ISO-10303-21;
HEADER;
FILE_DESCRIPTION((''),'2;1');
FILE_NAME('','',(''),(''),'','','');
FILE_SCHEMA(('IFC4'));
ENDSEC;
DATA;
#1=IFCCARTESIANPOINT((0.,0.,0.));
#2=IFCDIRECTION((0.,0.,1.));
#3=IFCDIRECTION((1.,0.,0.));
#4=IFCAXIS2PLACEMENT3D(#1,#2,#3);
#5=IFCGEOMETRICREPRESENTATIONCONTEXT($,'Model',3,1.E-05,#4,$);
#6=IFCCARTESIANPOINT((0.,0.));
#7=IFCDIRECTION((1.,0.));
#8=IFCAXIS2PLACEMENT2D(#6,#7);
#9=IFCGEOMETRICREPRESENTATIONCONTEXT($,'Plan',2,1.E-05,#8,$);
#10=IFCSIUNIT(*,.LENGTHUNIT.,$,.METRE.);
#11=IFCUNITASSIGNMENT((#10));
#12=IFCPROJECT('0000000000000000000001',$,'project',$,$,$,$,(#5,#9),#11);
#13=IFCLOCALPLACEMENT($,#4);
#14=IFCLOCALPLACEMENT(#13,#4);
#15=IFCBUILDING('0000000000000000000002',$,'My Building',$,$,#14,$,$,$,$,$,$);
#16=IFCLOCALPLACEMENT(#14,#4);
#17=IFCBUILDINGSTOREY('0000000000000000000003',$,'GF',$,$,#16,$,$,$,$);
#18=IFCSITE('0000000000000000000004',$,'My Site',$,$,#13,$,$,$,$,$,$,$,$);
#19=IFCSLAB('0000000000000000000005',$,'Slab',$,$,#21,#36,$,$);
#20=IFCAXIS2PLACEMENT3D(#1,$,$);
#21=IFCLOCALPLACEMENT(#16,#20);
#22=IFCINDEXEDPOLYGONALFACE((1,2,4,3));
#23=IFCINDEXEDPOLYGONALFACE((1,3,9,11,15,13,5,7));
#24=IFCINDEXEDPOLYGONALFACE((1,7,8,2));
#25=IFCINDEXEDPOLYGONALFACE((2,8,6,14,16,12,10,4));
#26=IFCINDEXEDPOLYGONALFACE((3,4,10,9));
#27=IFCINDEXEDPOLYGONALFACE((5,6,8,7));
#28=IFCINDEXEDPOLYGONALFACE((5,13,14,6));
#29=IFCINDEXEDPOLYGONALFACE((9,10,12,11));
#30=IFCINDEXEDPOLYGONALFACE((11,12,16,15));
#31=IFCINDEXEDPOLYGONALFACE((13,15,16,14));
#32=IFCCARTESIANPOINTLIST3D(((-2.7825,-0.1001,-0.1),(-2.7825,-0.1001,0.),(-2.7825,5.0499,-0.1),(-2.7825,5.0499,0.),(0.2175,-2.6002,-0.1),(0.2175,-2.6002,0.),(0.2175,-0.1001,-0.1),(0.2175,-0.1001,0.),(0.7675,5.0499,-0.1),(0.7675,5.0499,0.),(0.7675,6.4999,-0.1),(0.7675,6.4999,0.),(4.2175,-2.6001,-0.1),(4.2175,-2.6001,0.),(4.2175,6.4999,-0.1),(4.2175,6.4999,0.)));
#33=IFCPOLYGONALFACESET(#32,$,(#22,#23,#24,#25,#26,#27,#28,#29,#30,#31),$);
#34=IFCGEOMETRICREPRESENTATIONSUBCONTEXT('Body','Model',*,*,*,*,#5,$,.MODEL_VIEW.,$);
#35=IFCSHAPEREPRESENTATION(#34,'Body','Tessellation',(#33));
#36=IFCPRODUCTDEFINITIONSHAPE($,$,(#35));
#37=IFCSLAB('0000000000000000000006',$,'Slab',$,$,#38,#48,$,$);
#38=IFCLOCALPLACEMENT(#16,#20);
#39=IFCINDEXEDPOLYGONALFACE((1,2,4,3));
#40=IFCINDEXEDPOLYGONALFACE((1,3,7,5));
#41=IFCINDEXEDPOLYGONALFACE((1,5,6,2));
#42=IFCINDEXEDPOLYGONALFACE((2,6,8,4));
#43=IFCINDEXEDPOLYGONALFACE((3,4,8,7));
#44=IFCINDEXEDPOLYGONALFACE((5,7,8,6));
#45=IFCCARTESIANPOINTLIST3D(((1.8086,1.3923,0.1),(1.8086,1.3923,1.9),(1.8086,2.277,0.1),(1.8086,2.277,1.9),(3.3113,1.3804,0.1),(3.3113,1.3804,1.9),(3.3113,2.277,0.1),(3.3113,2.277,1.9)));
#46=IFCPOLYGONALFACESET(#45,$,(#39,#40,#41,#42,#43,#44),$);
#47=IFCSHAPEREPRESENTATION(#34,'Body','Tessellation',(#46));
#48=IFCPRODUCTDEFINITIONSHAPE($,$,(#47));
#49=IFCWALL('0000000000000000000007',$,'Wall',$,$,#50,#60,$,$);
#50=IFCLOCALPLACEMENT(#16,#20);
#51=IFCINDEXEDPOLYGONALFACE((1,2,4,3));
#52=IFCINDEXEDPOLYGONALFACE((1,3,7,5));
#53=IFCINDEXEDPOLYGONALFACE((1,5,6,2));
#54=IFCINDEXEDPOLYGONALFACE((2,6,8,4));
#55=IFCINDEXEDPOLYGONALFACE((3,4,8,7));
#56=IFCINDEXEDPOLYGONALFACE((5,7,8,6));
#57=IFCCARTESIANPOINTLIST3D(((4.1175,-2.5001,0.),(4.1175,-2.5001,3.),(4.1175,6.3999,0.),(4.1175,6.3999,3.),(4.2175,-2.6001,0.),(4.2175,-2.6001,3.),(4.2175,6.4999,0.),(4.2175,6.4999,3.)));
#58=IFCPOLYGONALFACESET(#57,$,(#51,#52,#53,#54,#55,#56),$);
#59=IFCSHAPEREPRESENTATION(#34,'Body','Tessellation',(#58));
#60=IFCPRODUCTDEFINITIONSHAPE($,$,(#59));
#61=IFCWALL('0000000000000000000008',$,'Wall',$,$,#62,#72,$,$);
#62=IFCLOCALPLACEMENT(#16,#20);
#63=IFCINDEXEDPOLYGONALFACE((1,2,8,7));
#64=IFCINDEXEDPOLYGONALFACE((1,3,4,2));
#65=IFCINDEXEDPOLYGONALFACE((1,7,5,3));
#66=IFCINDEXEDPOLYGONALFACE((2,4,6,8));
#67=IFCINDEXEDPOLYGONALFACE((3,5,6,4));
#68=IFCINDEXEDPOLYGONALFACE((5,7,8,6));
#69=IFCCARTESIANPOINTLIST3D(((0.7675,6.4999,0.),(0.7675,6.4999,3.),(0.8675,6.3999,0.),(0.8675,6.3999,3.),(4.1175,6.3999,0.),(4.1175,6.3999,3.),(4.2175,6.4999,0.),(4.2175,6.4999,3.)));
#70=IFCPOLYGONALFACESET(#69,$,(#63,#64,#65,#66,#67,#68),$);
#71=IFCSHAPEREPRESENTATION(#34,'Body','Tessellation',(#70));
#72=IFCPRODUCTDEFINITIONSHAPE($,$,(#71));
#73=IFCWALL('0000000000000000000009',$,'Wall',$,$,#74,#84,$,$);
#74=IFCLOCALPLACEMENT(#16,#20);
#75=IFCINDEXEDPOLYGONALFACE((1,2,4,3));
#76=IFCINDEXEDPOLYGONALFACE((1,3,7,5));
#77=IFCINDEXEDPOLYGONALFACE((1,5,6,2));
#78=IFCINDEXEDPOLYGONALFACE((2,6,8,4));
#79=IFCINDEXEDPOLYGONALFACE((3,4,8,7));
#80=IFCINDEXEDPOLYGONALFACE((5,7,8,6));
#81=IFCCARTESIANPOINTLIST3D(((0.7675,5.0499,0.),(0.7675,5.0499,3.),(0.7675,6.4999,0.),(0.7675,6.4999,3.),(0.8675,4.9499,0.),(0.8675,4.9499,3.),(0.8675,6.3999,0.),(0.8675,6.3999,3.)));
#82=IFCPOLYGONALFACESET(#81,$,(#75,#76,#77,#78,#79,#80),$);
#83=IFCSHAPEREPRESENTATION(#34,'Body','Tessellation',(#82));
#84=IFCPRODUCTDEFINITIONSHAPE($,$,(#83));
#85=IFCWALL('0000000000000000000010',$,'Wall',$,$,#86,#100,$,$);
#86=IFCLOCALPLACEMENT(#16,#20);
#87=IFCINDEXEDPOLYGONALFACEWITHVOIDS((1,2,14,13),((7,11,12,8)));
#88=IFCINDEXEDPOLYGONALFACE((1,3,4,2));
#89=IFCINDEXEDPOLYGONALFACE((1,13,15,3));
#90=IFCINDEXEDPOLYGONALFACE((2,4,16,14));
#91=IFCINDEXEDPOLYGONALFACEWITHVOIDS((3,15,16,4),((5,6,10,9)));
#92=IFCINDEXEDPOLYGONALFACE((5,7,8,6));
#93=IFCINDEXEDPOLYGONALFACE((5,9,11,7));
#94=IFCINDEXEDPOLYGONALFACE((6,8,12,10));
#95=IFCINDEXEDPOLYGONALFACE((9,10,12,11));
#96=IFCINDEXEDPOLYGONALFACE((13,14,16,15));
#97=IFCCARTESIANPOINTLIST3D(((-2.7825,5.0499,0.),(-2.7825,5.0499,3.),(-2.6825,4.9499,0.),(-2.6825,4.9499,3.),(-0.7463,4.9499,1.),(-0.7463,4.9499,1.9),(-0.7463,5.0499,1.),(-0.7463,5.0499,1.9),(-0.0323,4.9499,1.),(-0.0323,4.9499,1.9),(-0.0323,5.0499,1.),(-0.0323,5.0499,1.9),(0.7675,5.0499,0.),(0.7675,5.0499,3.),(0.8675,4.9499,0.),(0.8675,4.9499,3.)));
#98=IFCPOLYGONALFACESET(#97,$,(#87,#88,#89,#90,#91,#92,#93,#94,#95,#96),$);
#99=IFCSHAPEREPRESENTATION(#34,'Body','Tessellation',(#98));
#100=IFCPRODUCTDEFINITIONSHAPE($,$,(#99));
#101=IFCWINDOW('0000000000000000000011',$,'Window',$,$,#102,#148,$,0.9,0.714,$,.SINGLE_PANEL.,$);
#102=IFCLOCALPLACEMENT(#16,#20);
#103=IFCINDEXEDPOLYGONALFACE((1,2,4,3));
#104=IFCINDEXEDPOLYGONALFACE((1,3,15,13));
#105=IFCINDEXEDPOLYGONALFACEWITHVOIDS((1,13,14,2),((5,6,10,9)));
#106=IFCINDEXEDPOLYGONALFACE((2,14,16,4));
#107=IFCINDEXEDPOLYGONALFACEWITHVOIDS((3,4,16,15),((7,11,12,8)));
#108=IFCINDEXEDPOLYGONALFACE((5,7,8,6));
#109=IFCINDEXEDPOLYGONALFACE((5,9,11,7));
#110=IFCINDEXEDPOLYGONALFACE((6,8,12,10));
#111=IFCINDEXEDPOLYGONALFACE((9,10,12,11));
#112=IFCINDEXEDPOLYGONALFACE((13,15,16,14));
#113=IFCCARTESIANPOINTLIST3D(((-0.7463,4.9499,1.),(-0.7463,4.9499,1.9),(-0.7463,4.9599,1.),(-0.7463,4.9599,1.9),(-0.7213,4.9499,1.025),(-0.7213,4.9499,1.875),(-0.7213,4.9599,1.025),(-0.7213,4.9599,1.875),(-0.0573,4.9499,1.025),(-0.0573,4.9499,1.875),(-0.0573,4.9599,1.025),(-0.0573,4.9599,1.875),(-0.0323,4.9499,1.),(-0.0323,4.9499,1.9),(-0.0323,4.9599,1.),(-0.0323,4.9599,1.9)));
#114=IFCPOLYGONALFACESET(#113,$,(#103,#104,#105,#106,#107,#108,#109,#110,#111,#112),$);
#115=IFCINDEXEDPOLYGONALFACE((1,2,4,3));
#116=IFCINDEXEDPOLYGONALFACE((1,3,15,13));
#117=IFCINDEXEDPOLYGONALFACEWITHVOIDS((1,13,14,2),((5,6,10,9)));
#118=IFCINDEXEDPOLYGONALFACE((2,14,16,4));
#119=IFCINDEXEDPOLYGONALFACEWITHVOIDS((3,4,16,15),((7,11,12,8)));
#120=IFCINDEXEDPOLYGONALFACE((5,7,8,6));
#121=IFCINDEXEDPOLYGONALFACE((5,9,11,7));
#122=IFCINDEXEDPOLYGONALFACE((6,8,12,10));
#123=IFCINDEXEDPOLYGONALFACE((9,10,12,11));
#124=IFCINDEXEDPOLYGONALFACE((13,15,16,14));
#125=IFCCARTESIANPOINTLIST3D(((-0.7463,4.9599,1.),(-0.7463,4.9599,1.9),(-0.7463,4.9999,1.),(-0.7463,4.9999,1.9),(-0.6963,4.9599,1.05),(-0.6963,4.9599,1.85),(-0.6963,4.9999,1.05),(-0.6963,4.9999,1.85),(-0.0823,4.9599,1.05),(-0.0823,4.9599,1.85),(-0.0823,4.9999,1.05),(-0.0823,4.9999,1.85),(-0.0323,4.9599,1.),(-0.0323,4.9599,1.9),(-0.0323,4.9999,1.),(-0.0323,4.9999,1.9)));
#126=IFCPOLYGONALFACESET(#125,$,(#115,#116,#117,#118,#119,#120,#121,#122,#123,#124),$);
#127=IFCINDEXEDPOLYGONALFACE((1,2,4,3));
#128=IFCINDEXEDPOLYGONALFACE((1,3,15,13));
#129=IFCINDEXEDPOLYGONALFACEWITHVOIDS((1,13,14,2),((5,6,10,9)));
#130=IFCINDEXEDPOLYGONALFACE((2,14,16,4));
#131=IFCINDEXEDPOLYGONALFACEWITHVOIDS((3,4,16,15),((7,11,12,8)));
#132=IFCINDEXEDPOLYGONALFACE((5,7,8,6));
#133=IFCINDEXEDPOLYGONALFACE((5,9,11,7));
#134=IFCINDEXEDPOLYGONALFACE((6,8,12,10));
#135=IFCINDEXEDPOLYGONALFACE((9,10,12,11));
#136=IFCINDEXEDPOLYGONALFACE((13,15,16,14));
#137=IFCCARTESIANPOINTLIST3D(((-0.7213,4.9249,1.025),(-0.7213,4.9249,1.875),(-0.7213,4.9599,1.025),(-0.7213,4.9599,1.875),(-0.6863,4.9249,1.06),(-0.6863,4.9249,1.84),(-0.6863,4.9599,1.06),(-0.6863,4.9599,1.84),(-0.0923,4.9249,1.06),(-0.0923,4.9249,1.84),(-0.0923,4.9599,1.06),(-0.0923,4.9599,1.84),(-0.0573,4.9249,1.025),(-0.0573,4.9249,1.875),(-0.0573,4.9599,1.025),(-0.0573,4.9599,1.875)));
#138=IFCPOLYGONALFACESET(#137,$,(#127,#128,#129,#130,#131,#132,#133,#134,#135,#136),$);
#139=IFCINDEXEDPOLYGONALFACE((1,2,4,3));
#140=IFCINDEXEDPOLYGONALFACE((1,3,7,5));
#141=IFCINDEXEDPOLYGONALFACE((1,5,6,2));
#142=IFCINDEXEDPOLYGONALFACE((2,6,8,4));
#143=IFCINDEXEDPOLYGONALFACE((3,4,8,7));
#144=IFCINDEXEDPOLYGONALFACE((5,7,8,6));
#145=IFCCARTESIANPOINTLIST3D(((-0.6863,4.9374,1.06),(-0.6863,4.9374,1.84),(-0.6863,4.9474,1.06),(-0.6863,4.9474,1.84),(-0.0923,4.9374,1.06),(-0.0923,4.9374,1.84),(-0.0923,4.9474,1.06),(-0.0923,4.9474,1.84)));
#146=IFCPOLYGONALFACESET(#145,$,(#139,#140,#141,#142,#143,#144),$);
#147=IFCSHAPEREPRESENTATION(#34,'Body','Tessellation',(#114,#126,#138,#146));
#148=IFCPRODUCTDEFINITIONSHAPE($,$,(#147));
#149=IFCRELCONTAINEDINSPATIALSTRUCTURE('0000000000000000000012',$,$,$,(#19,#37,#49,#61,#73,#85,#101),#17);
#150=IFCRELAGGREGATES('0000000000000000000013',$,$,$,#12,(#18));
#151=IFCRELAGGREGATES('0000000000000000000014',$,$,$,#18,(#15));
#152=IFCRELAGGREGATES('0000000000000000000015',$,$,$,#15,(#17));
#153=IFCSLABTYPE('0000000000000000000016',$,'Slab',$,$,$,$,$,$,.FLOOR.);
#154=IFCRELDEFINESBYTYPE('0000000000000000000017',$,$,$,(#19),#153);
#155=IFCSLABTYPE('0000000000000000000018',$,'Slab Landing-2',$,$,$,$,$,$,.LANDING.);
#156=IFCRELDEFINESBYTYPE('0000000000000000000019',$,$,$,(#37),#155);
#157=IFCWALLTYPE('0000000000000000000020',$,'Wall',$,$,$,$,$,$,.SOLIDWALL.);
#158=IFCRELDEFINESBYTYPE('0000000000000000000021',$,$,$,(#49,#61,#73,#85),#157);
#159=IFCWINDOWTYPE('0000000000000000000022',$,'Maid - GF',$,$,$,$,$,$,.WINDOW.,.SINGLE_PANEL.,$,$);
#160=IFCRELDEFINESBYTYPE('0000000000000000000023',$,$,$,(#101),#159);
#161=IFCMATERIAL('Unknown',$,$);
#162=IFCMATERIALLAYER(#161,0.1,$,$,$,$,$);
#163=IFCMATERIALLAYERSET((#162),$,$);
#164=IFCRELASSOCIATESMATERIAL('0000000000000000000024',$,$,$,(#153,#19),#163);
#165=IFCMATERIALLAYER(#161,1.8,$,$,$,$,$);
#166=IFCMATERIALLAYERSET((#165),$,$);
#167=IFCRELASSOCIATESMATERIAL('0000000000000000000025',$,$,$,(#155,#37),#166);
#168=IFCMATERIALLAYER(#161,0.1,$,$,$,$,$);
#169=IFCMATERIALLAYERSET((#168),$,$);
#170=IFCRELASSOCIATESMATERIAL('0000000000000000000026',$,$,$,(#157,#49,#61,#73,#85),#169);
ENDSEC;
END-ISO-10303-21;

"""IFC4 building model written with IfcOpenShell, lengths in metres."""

from ifc_helpers import new_model, entity, si_unit, frame, origin_with_axes, origin_2d_with_axis, place, context, subcontext, project, spatial, line, indexed_curve, outline, extrude, shape, source, transform, mapped, material, layer, layer_set, layer_usage, type_object, type_shapes, element, fill, save


model = new_model("IFC4")

# Units and contexts
model_context = context("Model", 3, precision=1e-05, world=origin_with_axes())
plan_context = context("Plan", 2, precision=1e-05, world=origin_2d_with_axis())
body_context_1 = subcontext(model_context, "Body", "Model", "MODEL_VIEW")
body_context_2 = subcontext(plan_context, "Body", "Plan", "PLAN_VIEW")
ifc_project = project(units=[si_unit("LENGTHUNIT", "METRE")], contexts=[model_context, plan_context])

# Site, building, storey
site_placement = place(None, origin_with_axes())
site = spatial("IfcSite", under=ifc_project, at=site_placement, Name="My Site")
building_placement = place(site_placement, origin_with_axes())
building = spatial("IfcBuilding", under=site, at=building_placement, Name="My Building")
storey_placement = place(building_placement, origin_with_axes())
storey = spatial("IfcBuildingStorey", under=building, at=storey_placement, Name="GF")

# Slabs
ifc_material_1 = material(Name="Unknown")
ifc_layer_1 = layer(ifc_material_1, 0.1)
ifc_layer_set_1 = layer_set([ifc_layer_1])
ifc_layer_usage_1 = layer_usage(ifc_layer_set_1, "AXIS3", "POSITIVE", -0.1)
slab_type_1 = type_object("IfcSlabType", Name="Slab", PredefinedType="FLOOR", material=ifc_layer_set_1)
slab_1_placement = place(storey_placement, frame((4.2175, -2.6001, 0.0), z_axis=(0.0, 0.0, 1.0), x_axis=(1.0, 0.0, 0.0)))
element("IfcSlab", 1, at=slab_1_placement, inside=storey, type_object=slab_type_1, material=ifc_layer_usage_1, Name="Slab", context=body_context_1, shape_type="SweptSolid", body=[
    extrude(outline(indexed_curve([(0.0, 0.0), (0.0, 9.1), (-3.45, 9.1), (-3.45, 7.6499), (-7.0, 7.6499), (-7.0, 2.5), (-4.0, 2.5), (-4.0, -0.0001), (0.0, 0.0)])), frame((0.0, 0.0, -0.1), z_axis=(0.0, 0.0, 1.0), x_axis=(1.0, 0.0, 0.0)), (0.0, 0.0, 1.0), 0.1),
])
ifc_layer_2 = layer(ifc_material_1, 1.8)
ifc_layer_set_2 = layer_set([ifc_layer_2])
ifc_layer_usage_2 = layer_usage(ifc_layer_set_2, "AXIS3", "POSITIVE", -1.8)
slab_type_2 = type_object("IfcSlabType", Name="Slab Landing-2", PredefinedType="LANDING", material=ifc_layer_set_2)
slab_2_placement = place(storey_placement, frame((3.3113, 2.277, 1.9), z_axis=(0.0, 0.0, 1.0), x_axis=(1.0, 0.0, 0.0)))
element("IfcSlab", 2, at=slab_2_placement, inside=storey, type_object=slab_type_2, material=ifc_layer_usage_2, Name="Slab", context=body_context_1, shape_type="SweptSolid", body=[
    extrude(outline(indexed_curve([(0.0, 0.0), (0.0, -0.8966), (-1.5027, -0.8847), (-1.5027, 0.0), (0.0, 0.0)])), frame((0.0, 0.0, -1.8), z_axis=(0.0, 0.0, 1.0), x_axis=(1.0, 0.0, 0.0)), (0.0, 0.0, 1.0), 1.8),
])

# Shared definitions
ifc_layer_3 = layer(ifc_material_1, 0.1)
ifc_layer_set_3 = layer_set([ifc_layer_3])
wall_type = type_object("IfcWallType", Name="Wall", PredefinedType="SOLIDWALL", material=ifc_layer_set_3)

# Walls
ifc_layer_usage_3 = layer_usage(ifc_layer_set_3, "AXIS2", "POSITIVE", 0.0)
wall_1_placement = place(storey_placement, frame((4.2175, -2.6001, 0.0), z_axis=(0.0, 0.0, 1.0), x_axis=(0.0, 1.0, 0.0)))
element("IfcWall", 3, at=wall_1_placement, inside=storey, type_object=wall_type, material=ifc_layer_usage_3, Name="Wall", context=body_context_1, shape_type="SweptSolid", body=[
    extrude(outline(indexed_curve([(0.0, 0.0), (0.1, 0.1), (9.0, 0.1), (9.1, 0.0)], segments=[line(1, 2, 3, 4, 1)])), origin_with_axes(), (0.0, 0.0, 1.0), 3.0),
])
ifc_layer_usage_4 = layer_usage(ifc_layer_set_3, "AXIS2", "POSITIVE", 0.0)
wall_2_placement = place(storey_placement, frame((4.2175, 6.4999, 0.0), z_axis=(0.0, 0.0, 1.0), x_axis=(-1.0, 0.0, 0.0)))
element("IfcWall", 4, at=wall_2_placement, inside=storey, type_object=wall_type, material=ifc_layer_usage_4, Name="Wall", context=body_context_1, shape_type="SweptSolid", body=[
    extrude(outline(indexed_curve([(0.0, 0.0), (0.1, 0.1), (3.35, 0.1), (3.45, 0.0)], segments=[line(1, 2, 3, 4, 1)])), origin_with_axes(), (0.0, 0.0, 1.0), 3.0),
])
ifc_layer_usage_5 = layer_usage(ifc_layer_set_3, "AXIS2", "POSITIVE", 0.0)
wall_3_placement = place(storey_placement, frame((0.7675, 6.4999, 0.0), z_axis=(0.0, 0.0, 1.0), x_axis=(0.0, -1.0, 0.0)))
element("IfcWall", 5, at=wall_3_placement, inside=storey, type_object=wall_type, material=ifc_layer_usage_5, Name="Wall", context=body_context_1, shape_type="SweptSolid", body=[
    extrude(outline(indexed_curve([(0.0, 0.0), (0.1, 0.1), (1.55, 0.1), (1.45, 0.0)], segments=[line(1, 2, 3, 4, 1)])), origin_with_axes(), (0.0, 0.0, 1.0), 3.0),
])

# Wall, opening, window
ifc_layer_usage_6 = layer_usage(ifc_layer_set_3, "AXIS2", "POSITIVE", 0.0)
wall_4_placement = place(storey_placement, frame((0.7675, 5.0499, 0.0), z_axis=(0.0, 0.0, 1.0), x_axis=(-1.0, 0.0, 0.0)))
wall_4 = element("IfcWall", 6, at=wall_4_placement, inside=storey, type_object=wall_type, material=ifc_layer_usage_6, Name="Wall", context=body_context_1, shape_type="SweptSolid", body=[
    extrude(outline(indexed_curve([(0.0, 0.0), (-0.1, 0.1), (3.45, 0.1), (3.55, 0.0)], segments=[line(1, 2, 3, 4, 1)])), origin_with_axes(), (0.0, 0.0, 1.0), 3.0),
])
shared_shape_1 = source(origin_with_axes(), body_context_1, "Body", "SweptSolid", [
    extrude(outline(indexed_curve([(0.0, 0.0), (0.714, 0.0), (0.714, 0.9), (0.0, 0.9)], segments=[line(1, 2, 3, 4, 1)])), frame((0.0, -0.6, 0.0), z_axis=(0.0, -1.0, 0.0), x_axis=(1.0, 0.0, 0.0)), (0.0, 0.0, -1.0), 1.2),
])
opening_1_placement = place(wall_4_placement, frame((0.7998, 0.0, 1.0), z_axis=(0.0, 0.0, 1.0), x_axis=(1.0, 0.0, 0.0)))
opening_1 = element("IfcOpeningElement", 7, at=opening_1_placement, cuts=wall_4, PredefinedType="OPENING", context=body_context_1, shape_type="MappedRepresentation", body=[
    mapped(shared_shape_1, transform((0.0, 0.0, 0.0), x_axis=(1.0, 0.0, 0.0), y_axis=(0.0, 1.0, 0.0), z_axis=(0.0, 0.0, 1.0), scale=1.0)),
])
window_type_1 = type_object("IfcWindowType", Name="Maid - GF", PartitioningType="SINGLE_PANEL", PredefinedType="WINDOW")
shared_shape_2 = source(origin_with_axes(), body_context_1, "Body", "SweptSolid", [
    extrude(outline(indexed_curve([(0.0, 0.0), (0.714, 0.0), (0.714, 0.9), (0.0, 0.9)], segments=[line(1, 2, 3, 4, 1)]), holes=[indexed_curve([(0.025, 0.025), (0.689, 0.025), (0.689, 0.875), (0.025, 0.875)], segments=[line(1, 2, 3, 4, 1)])]), frame((0.0, 0.09, 0.0), z_axis=(0.0, -1.0, 0.0), x_axis=(1.0, 0.0, 0.0)), (0.0, 0.0, -1.0), 0.01),
    extrude(outline(indexed_curve([(0.0, 0.0), (0.714, 0.0), (0.714, 0.9), (0.0, 0.9)], segments=[line(1, 2, 3, 4, 1)]), holes=[indexed_curve([(0.05, 0.05), (0.664, 0.05), (0.664, 0.85), (0.05, 0.85)], segments=[line(1, 2, 3, 4, 1)])]), frame((0.0, 0.05, 0.0), z_axis=(0.0, -1.0, 0.0), x_axis=(1.0, 0.0, 0.0)), (0.0, 0.0, -1.0), 0.04),
    extrude(outline(indexed_curve([(0.0, 0.0), (0.664, 0.0), (0.664, 0.85), (0.0, 0.85)], segments=[line(1, 2, 3, 4, 1)]), holes=[indexed_curve([(0.035, 0.035), (0.629, 0.035), (0.629, 0.815), (0.035, 0.815)], segments=[line(1, 2, 3, 4, 1)])]), frame((0.025, 0.09, 0.025), z_axis=(0.0, -1.0, 0.0), x_axis=(1.0, 0.0, 0.0)), (0.0, 0.0, -1.0), 0.035),
    extrude(outline(indexed_curve([(0.035, 0.035), (0.629, 0.035), (0.629, 0.815), (0.035, 0.815)], segments=[line(1, 2, 3, 4, 1)])), frame((0.025, 0.1025, 0.025), z_axis=(0.0, -1.0, 0.0), x_axis=(1.0, 0.0, 0.0)), (0.0, 0.0, -1.0), 0.01),
])
shared_shape_3 = source(origin_with_axes(), body_context_2, "Body", "Curve2D", [
    entity("IfcIndexedPolyCurve", entity("IfcCartesianPointList2D", [[0.05, 0.05], [0.664, 0.05]])),
    entity("IfcIndexedPolyCurve", entity("IfcCartesianPointList2D", [[0.0, 0.1], [0.025, 0.1], [0.025, 0.09], [0.05, 0.09], [0.05, 0.05], [0.0, 0.05]]), [entity("IfcLineIndex", [1, 2, 3, 4, 5, 6, 1])]),
    entity("IfcIndexedPolyCurve", entity("IfcCartesianPointList2D", [[0.714, 0.1], [0.689, 0.1], [0.689, 0.09], [0.664, 0.09], [0.664, 0.05], [0.714, 0.05]]), [entity("IfcLineIndex", [1, 2, 3, 4, 5, 6, 1])]),
    entity("IfcIndexedPolyCurve", entity("IfcCartesianPointList2D", [[0.025, 0.09], [0.06, 0.09], [0.06, 0.125], [0.025, 0.125]]), [entity("IfcLineIndex", [1, 2, 3, 4, 1])]),
    entity("IfcIndexedPolyCurve", entity("IfcCartesianPointList2D", [[0.689, 0.09], [0.654, 0.09], [0.654, 0.125], [0.689, 0.125]]), [entity("IfcLineIndex", [1, 2, 3, 4, 1])]),
    entity("IfcIndexedPolyCurve", entity("IfcCartesianPointList2D", [[0.06, 0.09], [0.654, 0.09]])),
    entity("IfcIndexedPolyCurve", entity("IfcCartesianPointList2D", [[0.06, 0.125], [0.654, 0.125]])),
    entity("IfcIndexedPolyCurve", entity("IfcCartesianPointList2D", [[0.06, 0.1075], [0.654, 0.1075]])),
])
type_shapes(window_type_1, [shared_shape_2, shared_shape_3])
window_1_placement = place(opening_1_placement, frame((0.0, 0.0, 0.0), z_axis=(0.0, 0.0, 1.0), x_axis=(1.0, 0.0, 0.0)))
window_1 = element("IfcWindow", 8, at=window_1_placement, inside=storey, type_object=window_type_1, Name="Window", OverallHeight=0.9, OverallWidth=0.714, PartitioningType="SINGLE_PANEL", shapes=[
    shape(body_context_1, "Body", "MappedRepresentation", [mapped(shared_shape_2, transform((0.0, 0.0, 0.0), x_axis=(1.0, 0.0, 0.0), y_axis=(0.0, 1.0, 0.0), z_axis=(0.0, 0.0, 1.0), scale=1.0))]),
    shape(body_context_2, "Body", "MappedRepresentation", [mapped(shared_shape_3, transform((0.0, 0.0, 0.0), x_axis=(1.0, 0.0, 0.0), y_axis=(0.0, 1.0, 0.0), z_axis=(0.0, 0.0, 1.0), scale=1.0))]),
])
fill(opening_1, window_1)

save(model, "model.ifc")
